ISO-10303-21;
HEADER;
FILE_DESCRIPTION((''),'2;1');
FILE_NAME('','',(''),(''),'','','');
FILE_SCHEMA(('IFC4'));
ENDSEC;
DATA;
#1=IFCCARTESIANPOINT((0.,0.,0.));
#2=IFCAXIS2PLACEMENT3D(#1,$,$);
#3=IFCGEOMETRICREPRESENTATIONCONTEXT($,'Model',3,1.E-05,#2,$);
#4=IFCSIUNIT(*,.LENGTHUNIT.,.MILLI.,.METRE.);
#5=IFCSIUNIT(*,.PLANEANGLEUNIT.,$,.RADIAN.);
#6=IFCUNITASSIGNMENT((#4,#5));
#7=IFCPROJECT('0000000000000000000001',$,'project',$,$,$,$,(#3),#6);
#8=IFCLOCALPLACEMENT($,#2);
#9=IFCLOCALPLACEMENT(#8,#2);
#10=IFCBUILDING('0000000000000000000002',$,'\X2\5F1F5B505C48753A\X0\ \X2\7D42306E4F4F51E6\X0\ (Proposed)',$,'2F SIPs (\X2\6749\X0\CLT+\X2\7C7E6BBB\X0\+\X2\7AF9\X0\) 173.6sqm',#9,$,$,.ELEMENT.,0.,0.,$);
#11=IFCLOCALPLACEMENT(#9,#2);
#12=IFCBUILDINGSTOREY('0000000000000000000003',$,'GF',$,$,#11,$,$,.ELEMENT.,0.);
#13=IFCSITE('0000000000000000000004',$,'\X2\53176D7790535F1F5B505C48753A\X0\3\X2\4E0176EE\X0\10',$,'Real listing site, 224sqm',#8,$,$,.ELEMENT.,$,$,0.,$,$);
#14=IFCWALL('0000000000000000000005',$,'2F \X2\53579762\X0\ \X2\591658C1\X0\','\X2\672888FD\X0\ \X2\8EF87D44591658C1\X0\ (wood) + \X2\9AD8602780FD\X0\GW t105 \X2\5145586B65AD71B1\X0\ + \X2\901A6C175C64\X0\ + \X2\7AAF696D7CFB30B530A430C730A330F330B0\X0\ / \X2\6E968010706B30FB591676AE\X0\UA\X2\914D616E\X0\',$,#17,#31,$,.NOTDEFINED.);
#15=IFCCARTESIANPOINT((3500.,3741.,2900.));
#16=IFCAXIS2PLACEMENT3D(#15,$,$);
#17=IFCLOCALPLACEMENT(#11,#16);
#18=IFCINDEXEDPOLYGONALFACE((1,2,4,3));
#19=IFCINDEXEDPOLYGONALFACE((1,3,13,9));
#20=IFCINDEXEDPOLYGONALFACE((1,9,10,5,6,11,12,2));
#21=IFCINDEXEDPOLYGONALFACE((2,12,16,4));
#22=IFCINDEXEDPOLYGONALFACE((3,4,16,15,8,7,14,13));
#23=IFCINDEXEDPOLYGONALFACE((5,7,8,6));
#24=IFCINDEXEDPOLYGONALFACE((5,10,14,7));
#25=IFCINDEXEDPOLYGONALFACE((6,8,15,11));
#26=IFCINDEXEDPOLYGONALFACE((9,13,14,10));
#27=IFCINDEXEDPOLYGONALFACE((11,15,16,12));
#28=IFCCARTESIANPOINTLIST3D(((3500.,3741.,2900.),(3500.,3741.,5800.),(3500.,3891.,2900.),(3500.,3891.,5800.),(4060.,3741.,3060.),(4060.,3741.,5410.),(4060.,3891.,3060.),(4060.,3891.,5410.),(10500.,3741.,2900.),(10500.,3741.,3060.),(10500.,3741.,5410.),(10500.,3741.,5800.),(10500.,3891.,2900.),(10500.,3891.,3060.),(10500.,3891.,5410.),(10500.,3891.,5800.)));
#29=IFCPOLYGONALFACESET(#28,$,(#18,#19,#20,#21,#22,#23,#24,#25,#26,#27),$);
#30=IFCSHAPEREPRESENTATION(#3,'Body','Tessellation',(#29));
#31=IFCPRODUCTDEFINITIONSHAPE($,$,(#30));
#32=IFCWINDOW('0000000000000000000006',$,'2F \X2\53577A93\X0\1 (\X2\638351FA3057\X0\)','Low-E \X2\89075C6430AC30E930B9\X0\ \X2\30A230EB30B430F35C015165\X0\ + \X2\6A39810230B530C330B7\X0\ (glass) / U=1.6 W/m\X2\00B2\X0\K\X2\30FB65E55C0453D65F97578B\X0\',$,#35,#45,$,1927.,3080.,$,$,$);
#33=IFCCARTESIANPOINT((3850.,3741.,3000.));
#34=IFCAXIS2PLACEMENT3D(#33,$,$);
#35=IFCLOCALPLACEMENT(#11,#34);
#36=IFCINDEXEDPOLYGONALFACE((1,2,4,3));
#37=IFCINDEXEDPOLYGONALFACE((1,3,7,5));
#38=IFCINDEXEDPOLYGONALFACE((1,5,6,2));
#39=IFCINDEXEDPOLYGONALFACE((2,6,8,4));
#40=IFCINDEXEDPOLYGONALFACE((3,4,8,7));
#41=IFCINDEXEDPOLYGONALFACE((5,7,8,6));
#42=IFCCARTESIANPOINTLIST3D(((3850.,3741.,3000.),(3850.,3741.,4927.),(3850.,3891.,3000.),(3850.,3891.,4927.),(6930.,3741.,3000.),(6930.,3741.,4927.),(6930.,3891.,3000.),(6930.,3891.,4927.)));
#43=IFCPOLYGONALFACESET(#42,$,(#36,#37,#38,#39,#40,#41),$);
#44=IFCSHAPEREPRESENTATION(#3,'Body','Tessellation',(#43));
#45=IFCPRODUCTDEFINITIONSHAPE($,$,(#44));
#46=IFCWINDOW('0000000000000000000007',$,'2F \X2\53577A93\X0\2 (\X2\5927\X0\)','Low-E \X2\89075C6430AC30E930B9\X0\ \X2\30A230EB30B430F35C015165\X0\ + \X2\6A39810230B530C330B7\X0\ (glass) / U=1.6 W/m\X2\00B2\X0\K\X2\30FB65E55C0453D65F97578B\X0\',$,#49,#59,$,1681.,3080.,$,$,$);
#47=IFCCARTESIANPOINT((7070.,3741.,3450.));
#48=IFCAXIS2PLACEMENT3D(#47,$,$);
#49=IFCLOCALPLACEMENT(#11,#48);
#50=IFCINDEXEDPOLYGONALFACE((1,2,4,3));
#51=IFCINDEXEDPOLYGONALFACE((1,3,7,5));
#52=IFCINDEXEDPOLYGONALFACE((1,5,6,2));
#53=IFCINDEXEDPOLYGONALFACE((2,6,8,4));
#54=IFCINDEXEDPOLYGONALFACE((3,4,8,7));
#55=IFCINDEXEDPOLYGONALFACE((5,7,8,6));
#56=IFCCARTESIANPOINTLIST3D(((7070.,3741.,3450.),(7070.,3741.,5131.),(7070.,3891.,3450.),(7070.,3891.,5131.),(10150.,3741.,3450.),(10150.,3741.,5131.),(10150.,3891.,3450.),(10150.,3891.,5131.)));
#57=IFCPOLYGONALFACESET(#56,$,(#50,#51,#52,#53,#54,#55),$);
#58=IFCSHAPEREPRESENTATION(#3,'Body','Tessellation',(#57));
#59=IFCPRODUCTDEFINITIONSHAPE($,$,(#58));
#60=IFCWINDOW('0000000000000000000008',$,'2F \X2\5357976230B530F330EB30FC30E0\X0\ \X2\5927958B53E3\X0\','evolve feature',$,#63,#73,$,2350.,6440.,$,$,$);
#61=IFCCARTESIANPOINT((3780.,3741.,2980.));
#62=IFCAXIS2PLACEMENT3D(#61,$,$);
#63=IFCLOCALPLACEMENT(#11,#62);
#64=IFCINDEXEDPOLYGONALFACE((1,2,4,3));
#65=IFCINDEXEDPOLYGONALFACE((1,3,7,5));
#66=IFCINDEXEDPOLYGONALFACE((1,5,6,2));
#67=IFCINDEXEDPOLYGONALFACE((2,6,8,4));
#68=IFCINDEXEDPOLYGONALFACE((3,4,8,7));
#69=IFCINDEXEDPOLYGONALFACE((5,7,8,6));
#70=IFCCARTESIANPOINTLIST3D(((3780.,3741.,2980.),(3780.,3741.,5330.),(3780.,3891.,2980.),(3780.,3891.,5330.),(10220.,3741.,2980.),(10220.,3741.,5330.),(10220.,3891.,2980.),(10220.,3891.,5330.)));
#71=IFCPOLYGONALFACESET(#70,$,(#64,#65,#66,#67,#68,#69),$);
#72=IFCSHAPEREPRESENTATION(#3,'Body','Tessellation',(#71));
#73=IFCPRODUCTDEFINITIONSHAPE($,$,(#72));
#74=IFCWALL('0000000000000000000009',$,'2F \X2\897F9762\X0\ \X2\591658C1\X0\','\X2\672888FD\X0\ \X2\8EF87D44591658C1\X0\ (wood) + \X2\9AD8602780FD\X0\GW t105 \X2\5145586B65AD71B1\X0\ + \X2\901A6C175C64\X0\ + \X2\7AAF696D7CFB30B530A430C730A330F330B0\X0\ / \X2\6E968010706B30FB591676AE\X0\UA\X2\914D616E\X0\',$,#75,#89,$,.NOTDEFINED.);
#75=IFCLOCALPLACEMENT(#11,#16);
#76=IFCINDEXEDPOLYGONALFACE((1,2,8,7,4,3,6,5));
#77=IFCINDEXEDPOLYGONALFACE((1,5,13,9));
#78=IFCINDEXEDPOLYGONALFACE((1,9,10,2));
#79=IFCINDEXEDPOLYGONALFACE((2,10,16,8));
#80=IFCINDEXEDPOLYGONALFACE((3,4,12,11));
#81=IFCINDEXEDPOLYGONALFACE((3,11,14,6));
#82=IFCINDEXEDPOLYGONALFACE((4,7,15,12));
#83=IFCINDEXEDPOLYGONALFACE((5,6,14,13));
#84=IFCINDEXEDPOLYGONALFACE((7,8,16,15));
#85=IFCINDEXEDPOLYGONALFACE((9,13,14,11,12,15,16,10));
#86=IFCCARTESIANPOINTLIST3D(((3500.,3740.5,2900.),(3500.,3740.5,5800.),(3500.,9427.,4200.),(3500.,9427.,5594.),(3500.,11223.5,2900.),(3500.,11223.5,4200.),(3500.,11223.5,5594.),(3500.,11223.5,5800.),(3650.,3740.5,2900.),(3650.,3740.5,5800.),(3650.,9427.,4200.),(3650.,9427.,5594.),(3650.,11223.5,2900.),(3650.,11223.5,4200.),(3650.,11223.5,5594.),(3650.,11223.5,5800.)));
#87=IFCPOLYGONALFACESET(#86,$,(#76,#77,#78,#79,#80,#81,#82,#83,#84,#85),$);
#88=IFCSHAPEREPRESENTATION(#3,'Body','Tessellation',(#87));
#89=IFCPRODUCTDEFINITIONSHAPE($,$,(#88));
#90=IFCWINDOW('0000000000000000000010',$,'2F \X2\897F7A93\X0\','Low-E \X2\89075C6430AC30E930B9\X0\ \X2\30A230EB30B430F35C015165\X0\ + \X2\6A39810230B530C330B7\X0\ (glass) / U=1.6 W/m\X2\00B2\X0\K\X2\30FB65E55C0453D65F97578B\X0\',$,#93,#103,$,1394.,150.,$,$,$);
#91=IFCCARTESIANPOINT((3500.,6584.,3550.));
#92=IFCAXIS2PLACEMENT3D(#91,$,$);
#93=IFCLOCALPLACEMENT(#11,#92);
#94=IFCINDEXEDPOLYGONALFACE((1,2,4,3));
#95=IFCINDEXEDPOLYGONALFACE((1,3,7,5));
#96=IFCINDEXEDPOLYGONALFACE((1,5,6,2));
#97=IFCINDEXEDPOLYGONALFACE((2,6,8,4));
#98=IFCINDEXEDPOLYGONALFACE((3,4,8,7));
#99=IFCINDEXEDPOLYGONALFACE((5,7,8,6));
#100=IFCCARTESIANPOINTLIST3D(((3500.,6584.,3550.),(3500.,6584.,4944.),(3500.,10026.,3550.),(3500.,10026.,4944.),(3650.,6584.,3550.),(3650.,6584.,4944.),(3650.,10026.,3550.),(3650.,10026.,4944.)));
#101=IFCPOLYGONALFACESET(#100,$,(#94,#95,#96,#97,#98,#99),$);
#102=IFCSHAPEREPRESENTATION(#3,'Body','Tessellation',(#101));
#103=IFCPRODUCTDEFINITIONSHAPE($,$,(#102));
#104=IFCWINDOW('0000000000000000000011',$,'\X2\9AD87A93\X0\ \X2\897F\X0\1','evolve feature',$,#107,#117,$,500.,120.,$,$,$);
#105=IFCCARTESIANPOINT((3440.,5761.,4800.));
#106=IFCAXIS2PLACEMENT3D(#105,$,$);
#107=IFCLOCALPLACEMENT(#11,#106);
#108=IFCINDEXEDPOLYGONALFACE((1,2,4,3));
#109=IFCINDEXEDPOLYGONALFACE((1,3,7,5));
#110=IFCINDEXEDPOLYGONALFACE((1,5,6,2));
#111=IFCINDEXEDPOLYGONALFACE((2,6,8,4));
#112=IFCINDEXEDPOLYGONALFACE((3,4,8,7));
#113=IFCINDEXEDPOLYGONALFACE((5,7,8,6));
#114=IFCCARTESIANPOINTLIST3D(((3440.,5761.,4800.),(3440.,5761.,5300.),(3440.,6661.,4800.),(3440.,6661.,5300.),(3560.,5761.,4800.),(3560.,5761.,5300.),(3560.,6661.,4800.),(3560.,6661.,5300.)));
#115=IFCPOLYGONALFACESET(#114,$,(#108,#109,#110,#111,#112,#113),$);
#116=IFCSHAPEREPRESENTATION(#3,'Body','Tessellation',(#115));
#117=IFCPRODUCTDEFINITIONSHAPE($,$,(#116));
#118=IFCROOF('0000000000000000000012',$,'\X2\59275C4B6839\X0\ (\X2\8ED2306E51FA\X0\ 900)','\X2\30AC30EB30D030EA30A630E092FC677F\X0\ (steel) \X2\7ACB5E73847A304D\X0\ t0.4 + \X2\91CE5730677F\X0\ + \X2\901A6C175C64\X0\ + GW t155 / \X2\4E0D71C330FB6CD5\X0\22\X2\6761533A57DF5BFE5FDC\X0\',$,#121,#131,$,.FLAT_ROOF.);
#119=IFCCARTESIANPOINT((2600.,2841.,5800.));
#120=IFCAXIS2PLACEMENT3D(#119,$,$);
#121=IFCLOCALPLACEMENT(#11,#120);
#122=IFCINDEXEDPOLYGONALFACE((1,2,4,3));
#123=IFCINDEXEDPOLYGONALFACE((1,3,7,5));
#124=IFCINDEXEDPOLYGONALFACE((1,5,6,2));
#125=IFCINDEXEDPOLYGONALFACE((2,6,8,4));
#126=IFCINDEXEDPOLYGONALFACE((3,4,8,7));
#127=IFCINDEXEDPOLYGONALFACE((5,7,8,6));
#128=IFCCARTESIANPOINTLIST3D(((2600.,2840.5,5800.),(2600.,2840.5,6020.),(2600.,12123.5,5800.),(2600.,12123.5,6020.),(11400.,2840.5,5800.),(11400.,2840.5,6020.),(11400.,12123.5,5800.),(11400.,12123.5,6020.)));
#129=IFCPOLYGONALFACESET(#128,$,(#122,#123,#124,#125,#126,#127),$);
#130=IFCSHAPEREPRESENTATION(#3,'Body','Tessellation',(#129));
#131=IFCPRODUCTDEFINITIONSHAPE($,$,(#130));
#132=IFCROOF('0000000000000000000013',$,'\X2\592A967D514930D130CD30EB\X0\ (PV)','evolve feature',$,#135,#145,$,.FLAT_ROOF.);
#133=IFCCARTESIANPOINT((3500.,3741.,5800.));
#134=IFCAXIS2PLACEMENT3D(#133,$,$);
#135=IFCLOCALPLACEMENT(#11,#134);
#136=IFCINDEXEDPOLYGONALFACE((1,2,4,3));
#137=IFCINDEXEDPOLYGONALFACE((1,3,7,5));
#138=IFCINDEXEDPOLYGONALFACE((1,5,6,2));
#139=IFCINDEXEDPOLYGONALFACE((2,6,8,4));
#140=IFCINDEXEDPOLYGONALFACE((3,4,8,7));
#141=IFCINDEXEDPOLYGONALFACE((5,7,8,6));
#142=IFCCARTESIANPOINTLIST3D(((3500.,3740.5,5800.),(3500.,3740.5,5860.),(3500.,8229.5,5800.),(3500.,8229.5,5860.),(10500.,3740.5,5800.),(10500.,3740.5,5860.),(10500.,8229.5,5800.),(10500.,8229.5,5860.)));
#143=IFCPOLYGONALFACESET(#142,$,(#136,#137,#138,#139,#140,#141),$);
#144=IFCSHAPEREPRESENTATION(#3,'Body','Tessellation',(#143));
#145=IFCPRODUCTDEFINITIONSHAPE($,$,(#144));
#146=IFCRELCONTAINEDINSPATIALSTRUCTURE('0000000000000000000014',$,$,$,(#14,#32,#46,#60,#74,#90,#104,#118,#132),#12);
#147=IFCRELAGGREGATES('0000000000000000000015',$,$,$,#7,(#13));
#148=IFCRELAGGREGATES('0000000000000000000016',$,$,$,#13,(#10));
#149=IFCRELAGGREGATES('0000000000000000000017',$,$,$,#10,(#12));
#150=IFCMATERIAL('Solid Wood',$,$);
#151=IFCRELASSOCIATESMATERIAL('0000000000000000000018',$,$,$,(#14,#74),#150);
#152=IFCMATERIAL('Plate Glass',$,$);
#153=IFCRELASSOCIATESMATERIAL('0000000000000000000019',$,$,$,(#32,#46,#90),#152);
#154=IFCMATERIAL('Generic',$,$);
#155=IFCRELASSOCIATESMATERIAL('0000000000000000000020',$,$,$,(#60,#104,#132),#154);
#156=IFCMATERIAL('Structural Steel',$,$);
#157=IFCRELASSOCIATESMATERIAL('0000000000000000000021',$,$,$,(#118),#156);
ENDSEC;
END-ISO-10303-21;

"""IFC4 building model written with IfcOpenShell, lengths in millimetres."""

from ifc_helpers import new_model, si_unit, frame, frame_2d, origin, place, context, project, spatial, rectangle, extrude, material, element, fill, save


model = new_model("IFC4")

# Units and contexts
model_context = context("Model", 3, precision=1e-05, world=origin())
ifc_project = project(units=[si_unit("LENGTHUNIT", "METRE", prefix="MILLI"), si_unit("PLANEANGLEUNIT", "RADIAN")], contexts=[model_context])

# Site, building, storey
site_placement = place(None, origin())
site = spatial("IfcSite", under=ifc_project, at=site_placement, Name="北海道弟子屈町3丁目10", ObjectType="Real listing site, 224sqm", CompositionType="ELEMENT", RefElevation=0.0)
building_placement = place(site_placement, origin())
building = spatial("IfcBuilding", under=site, at=building_placement, Name="弟子屈町 終の住処 (Proposed)", ObjectType="2F SIPs (杉CLT+籾殻+竹) 173.6sqm", CompositionType="ELEMENT", ElevationOfRefHeight=0.0, ElevationOfTerrain=0.0)
storey_placement = place(building_placement, origin())
storey = spatial("IfcBuildingStorey", under=building, at=storey_placement, Name="GF", CompositionType="ELEMENT", Elevation=0.0)

# Shared definitions
ifc_material_1 = material(Name="Solid Wood")
ifc_material_2 = material(Name="Generic")

# Shared definitions
ifc_material_3 = material(Name="Plate Glass")

# Walls, openings, windows
wall_1_placement = place(storey_placement, frame((3500.0, 3741.0, 2900.0)))
wall_1 = element("IfcWall", 1, at=wall_1_placement, inside=storey, material=ifc_material_1, Name="2F 南面 外壁", Description="木製 軸組外壁 (wood) + 高性能GW t105 充填断熱 + 通気層 + 窯業系サイディング / 準耐火・外皮UA配慮", PredefinedType="NOTDEFINED", context=model_context, shape_type="SweptSolid", body=[
    extrude(rectangle(XDim=7000.0, YDim=150.0, at=frame_2d((3500.0, 75.0))), frame((3500.0, 3741.0, 2900.0)), (0.0, 0.0, 1.0), 2900.0),
])
opening_1_placement = place(storey_placement, frame((3850.0, 3741.0, 3000.0)))
opening_1 = element("IfcOpeningElement", 2, at=opening_1_placement, cuts=wall_1, PredefinedType="NOTDEFINED", context=model_context, shape_type="SweptSolid", body=[
    extrude(rectangle(XDim=3080.0, YDim=150.0, at=frame_2d((1540.0, 75.0))), frame((3850.0, 3741.0, 3000.0)), (0.0, 0.0, 1.0), 1927.0),
])
opening_2_placement = place(storey_placement, frame((7070.0, 3741.0, 3450.0)))
opening_2 = element("IfcOpeningElement", 3, at=opening_2_placement, cuts=wall_1, PredefinedType="NOTDEFINED", context=model_context, shape_type="SweptSolid", body=[
    extrude(rectangle(XDim=3080.0, YDim=150.0, at=frame_2d((1540.0, 75.0))), frame((7070.0, 3741.0, 3450.0)), (0.0, 0.0, 1.0), 1681.0),
])
opening_3_placement = place(storey_placement, frame((3780.0, 3741.0, 2980.0)))
opening_3 = element("IfcOpeningElement", 4, at=opening_3_placement, cuts=wall_1, PredefinedType="NOTDEFINED", context=model_context, shape_type="SweptSolid", body=[
    extrude(rectangle(XDim=6440.0, YDim=150.0, at=frame_2d((3220.0, 75.0))), frame((3780.0, 3741.0, 2980.0)), (0.0, 0.0, 1.0), 2350.0),
])
window_1_placement = place(storey_placement, frame((3850.0, 3741.0, 3000.0)))
window_1 = element("IfcWindow", 5, at=window_1_placement, inside=storey, material=ifc_material_3, Name="2F 南窓1 (掃出し)", Description="Low-E 複層ガラス アルゴン封入 + 樹脂サッシ (glass) / U=1.6 W/m²K・日射取得型", OverallHeight=1927.0, OverallWidth=3080.0, context=model_context, shape_type="SweptSolid", body=[
    extrude(rectangle(XDim=3080.0, YDim=150.0, at=frame_2d((1540.0, 75.0))), frame((3850.0, 3741.0, 3000.0)), (0.0, 0.0, 1.0), 1927.0),
])
fill(opening_1, window_1)
window_2_placement = place(storey_placement, frame((7070.0, 3741.0, 3450.0)))
window_2 = element("IfcWindow", 6, at=window_2_placement, inside=storey, material=ifc_material_3, Name="2F 南窓2 (大)", Description="Low-E 複層ガラス アルゴン封入 + 樹脂サッシ (glass) / U=1.6 W/m²K・日射取得型", OverallHeight=1681.0, OverallWidth=3080.0, context=model_context, shape_type="SweptSolid", body=[
    extrude(rectangle(XDim=3080.0, YDim=150.0, at=frame_2d((1540.0, 75.0))), frame((7070.0, 3741.0, 3450.0)), (0.0, 0.0, 1.0), 1681.0),
])
fill(opening_2, window_2)
window_3_placement = place(storey_placement, frame((3780.0, 3741.0, 2980.0)))
window_3 = element("IfcWindow", 7, at=window_3_placement, inside=storey, material=ifc_material_2, Name="2F 南面サンルーム 大開口", Description="evolve feature", OverallHeight=2350.0, OverallWidth=6440.0, context=model_context, shape_type="SweptSolid", body=[
    extrude(rectangle(XDim=6440.0, YDim=150.0, at=frame_2d((3220.0, 75.0))), frame((3780.0, 3741.0, 2980.0)), (0.0, 0.0, 1.0), 2350.0),
])
fill(opening_3, window_3)
wall_2_placement = place(storey_placement, frame((3500.0, 3741.0, 2900.0)))
wall_2 = element("IfcWall", 8, at=wall_2_placement, inside=storey, material=ifc_material_1, Name="2F 西面 外壁", Description="木製 軸組外壁 (wood) + 高性能GW t105 充填断熱 + 通気層 + 窯業系サイディング / 準耐火・外皮UA配慮", PredefinedType="NOTDEFINED", context=model_context, shape_type="SweptSolid", body=[
    extrude(rectangle(XDim=150.0, YDim=7483.0, at=frame_2d((75.0, 3741.0))), frame((3500.0, 3741.0, 2900.0)), (0.0, 0.0, 1.0), 2900.0),
])
opening_4_placement = place(storey_placement, frame((3500.0, 6584.0, 3550.0)))
opening_4 = element("IfcOpeningElement", 9, at=opening_4_placement, cuts=wall_2, PredefinedType="NOTDEFINED", context=model_context, shape_type="SweptSolid", body=[
    extrude(rectangle(XDim=150.0, YDim=3442.0, at=frame_2d((75.0, 1721.0))), frame((3500.0, 6584.0, 3550.0)), (0.0, 0.0, 1.0), 1394.0),
])
opening_5_placement = place(storey_placement, frame((3440.0, 5761.0, 4800.0)))
opening_5 = element("IfcOpeningElement", 10, at=opening_5_placement, cuts=wall_2, PredefinedType="NOTDEFINED", context=model_context, shape_type="SweptSolid", body=[
    extrude(rectangle(XDim=120.0, YDim=900.0, at=frame_2d((60.0, 450.0))), frame((3440.0, 5761.0, 4800.0)), (0.0, 0.0, 1.0), 500.0),
])
window_4_placement = place(storey_placement, frame((3500.0, 6584.0, 3550.0)))
window_4 = element("IfcWindow", 11, at=window_4_placement, inside=storey, material=ifc_material_3, Name="2F 西窓", Description="Low-E 複層ガラス アルゴン封入 + 樹脂サッシ (glass) / U=1.6 W/m²K・日射取得型", OverallHeight=1394.0, OverallWidth=150.0, context=model_context, shape_type="SweptSolid", body=[
    extrude(rectangle(XDim=150.0, YDim=3442.0, at=frame_2d((75.0, 1721.0))), frame((3500.0, 6584.0, 3550.0)), (0.0, 0.0, 1.0), 1394.0),
])
fill(opening_4, window_4)
window_5_placement = place(storey_placement, frame((3440.0, 5761.0, 4800.0)))
window_5 = element("IfcWindow", 12, at=window_5_placement, inside=storey, material=ifc_material_2, Name="高窓 西1", Description="evolve feature", OverallHeight=500.0, OverallWidth=120.0, context=model_context, shape_type="SweptSolid", body=[
    extrude(rectangle(XDim=120.0, YDim=900.0, at=frame_2d((60.0, 450.0))), frame((3440.0, 5761.0, 4800.0)), (0.0, 0.0, 1.0), 500.0),
])
fill(opening_5, window_5)

# Roofs
ifc_material_4 = material(Name="Structural Steel")
roof_1_placement = place(storey_placement, frame((2600.0, 2841.0, 5800.0)))
element("IfcRoof", 13, at=roof_1_placement, inside=storey, material=ifc_material_4, Name="大屋根 (軒の出 900)", Description="ガルバリウム鋼板 (steel) 立平葺き t0.4 + 野地板 + 通気層 + GW t155 / 不燃・法22条区域対応", PredefinedType="FLAT_ROOF", context=model_context, shape_type="SweptSolid", body=[
    extrude(rectangle(XDim=8800.0, YDim=9283.0, at=frame_2d((4400.0, 4641.0))), frame((2600.0, 2841.0, 5800.0)), (0.0, 0.0, 1.0), 220.0),
])
roof_2_placement = place(storey_placement, frame((3500.0, 3741.0, 5800.0)))
element("IfcRoof", 14, at=roof_2_placement, inside=storey, material=ifc_material_2, Name="太陽光パネル (PV)", Description="evolve feature", PredefinedType="FLAT_ROOF", context=model_context, shape_type="SweptSolid", body=[
    extrude(rectangle(XDim=7000.0, YDim=4489.0, at=frame_2d((3500.0, 2244.0))), frame((3500.0, 3741.0, 5800.0)), (0.0, 0.0, 1.0), 60.0),
])

save(model, "model.ifc")
